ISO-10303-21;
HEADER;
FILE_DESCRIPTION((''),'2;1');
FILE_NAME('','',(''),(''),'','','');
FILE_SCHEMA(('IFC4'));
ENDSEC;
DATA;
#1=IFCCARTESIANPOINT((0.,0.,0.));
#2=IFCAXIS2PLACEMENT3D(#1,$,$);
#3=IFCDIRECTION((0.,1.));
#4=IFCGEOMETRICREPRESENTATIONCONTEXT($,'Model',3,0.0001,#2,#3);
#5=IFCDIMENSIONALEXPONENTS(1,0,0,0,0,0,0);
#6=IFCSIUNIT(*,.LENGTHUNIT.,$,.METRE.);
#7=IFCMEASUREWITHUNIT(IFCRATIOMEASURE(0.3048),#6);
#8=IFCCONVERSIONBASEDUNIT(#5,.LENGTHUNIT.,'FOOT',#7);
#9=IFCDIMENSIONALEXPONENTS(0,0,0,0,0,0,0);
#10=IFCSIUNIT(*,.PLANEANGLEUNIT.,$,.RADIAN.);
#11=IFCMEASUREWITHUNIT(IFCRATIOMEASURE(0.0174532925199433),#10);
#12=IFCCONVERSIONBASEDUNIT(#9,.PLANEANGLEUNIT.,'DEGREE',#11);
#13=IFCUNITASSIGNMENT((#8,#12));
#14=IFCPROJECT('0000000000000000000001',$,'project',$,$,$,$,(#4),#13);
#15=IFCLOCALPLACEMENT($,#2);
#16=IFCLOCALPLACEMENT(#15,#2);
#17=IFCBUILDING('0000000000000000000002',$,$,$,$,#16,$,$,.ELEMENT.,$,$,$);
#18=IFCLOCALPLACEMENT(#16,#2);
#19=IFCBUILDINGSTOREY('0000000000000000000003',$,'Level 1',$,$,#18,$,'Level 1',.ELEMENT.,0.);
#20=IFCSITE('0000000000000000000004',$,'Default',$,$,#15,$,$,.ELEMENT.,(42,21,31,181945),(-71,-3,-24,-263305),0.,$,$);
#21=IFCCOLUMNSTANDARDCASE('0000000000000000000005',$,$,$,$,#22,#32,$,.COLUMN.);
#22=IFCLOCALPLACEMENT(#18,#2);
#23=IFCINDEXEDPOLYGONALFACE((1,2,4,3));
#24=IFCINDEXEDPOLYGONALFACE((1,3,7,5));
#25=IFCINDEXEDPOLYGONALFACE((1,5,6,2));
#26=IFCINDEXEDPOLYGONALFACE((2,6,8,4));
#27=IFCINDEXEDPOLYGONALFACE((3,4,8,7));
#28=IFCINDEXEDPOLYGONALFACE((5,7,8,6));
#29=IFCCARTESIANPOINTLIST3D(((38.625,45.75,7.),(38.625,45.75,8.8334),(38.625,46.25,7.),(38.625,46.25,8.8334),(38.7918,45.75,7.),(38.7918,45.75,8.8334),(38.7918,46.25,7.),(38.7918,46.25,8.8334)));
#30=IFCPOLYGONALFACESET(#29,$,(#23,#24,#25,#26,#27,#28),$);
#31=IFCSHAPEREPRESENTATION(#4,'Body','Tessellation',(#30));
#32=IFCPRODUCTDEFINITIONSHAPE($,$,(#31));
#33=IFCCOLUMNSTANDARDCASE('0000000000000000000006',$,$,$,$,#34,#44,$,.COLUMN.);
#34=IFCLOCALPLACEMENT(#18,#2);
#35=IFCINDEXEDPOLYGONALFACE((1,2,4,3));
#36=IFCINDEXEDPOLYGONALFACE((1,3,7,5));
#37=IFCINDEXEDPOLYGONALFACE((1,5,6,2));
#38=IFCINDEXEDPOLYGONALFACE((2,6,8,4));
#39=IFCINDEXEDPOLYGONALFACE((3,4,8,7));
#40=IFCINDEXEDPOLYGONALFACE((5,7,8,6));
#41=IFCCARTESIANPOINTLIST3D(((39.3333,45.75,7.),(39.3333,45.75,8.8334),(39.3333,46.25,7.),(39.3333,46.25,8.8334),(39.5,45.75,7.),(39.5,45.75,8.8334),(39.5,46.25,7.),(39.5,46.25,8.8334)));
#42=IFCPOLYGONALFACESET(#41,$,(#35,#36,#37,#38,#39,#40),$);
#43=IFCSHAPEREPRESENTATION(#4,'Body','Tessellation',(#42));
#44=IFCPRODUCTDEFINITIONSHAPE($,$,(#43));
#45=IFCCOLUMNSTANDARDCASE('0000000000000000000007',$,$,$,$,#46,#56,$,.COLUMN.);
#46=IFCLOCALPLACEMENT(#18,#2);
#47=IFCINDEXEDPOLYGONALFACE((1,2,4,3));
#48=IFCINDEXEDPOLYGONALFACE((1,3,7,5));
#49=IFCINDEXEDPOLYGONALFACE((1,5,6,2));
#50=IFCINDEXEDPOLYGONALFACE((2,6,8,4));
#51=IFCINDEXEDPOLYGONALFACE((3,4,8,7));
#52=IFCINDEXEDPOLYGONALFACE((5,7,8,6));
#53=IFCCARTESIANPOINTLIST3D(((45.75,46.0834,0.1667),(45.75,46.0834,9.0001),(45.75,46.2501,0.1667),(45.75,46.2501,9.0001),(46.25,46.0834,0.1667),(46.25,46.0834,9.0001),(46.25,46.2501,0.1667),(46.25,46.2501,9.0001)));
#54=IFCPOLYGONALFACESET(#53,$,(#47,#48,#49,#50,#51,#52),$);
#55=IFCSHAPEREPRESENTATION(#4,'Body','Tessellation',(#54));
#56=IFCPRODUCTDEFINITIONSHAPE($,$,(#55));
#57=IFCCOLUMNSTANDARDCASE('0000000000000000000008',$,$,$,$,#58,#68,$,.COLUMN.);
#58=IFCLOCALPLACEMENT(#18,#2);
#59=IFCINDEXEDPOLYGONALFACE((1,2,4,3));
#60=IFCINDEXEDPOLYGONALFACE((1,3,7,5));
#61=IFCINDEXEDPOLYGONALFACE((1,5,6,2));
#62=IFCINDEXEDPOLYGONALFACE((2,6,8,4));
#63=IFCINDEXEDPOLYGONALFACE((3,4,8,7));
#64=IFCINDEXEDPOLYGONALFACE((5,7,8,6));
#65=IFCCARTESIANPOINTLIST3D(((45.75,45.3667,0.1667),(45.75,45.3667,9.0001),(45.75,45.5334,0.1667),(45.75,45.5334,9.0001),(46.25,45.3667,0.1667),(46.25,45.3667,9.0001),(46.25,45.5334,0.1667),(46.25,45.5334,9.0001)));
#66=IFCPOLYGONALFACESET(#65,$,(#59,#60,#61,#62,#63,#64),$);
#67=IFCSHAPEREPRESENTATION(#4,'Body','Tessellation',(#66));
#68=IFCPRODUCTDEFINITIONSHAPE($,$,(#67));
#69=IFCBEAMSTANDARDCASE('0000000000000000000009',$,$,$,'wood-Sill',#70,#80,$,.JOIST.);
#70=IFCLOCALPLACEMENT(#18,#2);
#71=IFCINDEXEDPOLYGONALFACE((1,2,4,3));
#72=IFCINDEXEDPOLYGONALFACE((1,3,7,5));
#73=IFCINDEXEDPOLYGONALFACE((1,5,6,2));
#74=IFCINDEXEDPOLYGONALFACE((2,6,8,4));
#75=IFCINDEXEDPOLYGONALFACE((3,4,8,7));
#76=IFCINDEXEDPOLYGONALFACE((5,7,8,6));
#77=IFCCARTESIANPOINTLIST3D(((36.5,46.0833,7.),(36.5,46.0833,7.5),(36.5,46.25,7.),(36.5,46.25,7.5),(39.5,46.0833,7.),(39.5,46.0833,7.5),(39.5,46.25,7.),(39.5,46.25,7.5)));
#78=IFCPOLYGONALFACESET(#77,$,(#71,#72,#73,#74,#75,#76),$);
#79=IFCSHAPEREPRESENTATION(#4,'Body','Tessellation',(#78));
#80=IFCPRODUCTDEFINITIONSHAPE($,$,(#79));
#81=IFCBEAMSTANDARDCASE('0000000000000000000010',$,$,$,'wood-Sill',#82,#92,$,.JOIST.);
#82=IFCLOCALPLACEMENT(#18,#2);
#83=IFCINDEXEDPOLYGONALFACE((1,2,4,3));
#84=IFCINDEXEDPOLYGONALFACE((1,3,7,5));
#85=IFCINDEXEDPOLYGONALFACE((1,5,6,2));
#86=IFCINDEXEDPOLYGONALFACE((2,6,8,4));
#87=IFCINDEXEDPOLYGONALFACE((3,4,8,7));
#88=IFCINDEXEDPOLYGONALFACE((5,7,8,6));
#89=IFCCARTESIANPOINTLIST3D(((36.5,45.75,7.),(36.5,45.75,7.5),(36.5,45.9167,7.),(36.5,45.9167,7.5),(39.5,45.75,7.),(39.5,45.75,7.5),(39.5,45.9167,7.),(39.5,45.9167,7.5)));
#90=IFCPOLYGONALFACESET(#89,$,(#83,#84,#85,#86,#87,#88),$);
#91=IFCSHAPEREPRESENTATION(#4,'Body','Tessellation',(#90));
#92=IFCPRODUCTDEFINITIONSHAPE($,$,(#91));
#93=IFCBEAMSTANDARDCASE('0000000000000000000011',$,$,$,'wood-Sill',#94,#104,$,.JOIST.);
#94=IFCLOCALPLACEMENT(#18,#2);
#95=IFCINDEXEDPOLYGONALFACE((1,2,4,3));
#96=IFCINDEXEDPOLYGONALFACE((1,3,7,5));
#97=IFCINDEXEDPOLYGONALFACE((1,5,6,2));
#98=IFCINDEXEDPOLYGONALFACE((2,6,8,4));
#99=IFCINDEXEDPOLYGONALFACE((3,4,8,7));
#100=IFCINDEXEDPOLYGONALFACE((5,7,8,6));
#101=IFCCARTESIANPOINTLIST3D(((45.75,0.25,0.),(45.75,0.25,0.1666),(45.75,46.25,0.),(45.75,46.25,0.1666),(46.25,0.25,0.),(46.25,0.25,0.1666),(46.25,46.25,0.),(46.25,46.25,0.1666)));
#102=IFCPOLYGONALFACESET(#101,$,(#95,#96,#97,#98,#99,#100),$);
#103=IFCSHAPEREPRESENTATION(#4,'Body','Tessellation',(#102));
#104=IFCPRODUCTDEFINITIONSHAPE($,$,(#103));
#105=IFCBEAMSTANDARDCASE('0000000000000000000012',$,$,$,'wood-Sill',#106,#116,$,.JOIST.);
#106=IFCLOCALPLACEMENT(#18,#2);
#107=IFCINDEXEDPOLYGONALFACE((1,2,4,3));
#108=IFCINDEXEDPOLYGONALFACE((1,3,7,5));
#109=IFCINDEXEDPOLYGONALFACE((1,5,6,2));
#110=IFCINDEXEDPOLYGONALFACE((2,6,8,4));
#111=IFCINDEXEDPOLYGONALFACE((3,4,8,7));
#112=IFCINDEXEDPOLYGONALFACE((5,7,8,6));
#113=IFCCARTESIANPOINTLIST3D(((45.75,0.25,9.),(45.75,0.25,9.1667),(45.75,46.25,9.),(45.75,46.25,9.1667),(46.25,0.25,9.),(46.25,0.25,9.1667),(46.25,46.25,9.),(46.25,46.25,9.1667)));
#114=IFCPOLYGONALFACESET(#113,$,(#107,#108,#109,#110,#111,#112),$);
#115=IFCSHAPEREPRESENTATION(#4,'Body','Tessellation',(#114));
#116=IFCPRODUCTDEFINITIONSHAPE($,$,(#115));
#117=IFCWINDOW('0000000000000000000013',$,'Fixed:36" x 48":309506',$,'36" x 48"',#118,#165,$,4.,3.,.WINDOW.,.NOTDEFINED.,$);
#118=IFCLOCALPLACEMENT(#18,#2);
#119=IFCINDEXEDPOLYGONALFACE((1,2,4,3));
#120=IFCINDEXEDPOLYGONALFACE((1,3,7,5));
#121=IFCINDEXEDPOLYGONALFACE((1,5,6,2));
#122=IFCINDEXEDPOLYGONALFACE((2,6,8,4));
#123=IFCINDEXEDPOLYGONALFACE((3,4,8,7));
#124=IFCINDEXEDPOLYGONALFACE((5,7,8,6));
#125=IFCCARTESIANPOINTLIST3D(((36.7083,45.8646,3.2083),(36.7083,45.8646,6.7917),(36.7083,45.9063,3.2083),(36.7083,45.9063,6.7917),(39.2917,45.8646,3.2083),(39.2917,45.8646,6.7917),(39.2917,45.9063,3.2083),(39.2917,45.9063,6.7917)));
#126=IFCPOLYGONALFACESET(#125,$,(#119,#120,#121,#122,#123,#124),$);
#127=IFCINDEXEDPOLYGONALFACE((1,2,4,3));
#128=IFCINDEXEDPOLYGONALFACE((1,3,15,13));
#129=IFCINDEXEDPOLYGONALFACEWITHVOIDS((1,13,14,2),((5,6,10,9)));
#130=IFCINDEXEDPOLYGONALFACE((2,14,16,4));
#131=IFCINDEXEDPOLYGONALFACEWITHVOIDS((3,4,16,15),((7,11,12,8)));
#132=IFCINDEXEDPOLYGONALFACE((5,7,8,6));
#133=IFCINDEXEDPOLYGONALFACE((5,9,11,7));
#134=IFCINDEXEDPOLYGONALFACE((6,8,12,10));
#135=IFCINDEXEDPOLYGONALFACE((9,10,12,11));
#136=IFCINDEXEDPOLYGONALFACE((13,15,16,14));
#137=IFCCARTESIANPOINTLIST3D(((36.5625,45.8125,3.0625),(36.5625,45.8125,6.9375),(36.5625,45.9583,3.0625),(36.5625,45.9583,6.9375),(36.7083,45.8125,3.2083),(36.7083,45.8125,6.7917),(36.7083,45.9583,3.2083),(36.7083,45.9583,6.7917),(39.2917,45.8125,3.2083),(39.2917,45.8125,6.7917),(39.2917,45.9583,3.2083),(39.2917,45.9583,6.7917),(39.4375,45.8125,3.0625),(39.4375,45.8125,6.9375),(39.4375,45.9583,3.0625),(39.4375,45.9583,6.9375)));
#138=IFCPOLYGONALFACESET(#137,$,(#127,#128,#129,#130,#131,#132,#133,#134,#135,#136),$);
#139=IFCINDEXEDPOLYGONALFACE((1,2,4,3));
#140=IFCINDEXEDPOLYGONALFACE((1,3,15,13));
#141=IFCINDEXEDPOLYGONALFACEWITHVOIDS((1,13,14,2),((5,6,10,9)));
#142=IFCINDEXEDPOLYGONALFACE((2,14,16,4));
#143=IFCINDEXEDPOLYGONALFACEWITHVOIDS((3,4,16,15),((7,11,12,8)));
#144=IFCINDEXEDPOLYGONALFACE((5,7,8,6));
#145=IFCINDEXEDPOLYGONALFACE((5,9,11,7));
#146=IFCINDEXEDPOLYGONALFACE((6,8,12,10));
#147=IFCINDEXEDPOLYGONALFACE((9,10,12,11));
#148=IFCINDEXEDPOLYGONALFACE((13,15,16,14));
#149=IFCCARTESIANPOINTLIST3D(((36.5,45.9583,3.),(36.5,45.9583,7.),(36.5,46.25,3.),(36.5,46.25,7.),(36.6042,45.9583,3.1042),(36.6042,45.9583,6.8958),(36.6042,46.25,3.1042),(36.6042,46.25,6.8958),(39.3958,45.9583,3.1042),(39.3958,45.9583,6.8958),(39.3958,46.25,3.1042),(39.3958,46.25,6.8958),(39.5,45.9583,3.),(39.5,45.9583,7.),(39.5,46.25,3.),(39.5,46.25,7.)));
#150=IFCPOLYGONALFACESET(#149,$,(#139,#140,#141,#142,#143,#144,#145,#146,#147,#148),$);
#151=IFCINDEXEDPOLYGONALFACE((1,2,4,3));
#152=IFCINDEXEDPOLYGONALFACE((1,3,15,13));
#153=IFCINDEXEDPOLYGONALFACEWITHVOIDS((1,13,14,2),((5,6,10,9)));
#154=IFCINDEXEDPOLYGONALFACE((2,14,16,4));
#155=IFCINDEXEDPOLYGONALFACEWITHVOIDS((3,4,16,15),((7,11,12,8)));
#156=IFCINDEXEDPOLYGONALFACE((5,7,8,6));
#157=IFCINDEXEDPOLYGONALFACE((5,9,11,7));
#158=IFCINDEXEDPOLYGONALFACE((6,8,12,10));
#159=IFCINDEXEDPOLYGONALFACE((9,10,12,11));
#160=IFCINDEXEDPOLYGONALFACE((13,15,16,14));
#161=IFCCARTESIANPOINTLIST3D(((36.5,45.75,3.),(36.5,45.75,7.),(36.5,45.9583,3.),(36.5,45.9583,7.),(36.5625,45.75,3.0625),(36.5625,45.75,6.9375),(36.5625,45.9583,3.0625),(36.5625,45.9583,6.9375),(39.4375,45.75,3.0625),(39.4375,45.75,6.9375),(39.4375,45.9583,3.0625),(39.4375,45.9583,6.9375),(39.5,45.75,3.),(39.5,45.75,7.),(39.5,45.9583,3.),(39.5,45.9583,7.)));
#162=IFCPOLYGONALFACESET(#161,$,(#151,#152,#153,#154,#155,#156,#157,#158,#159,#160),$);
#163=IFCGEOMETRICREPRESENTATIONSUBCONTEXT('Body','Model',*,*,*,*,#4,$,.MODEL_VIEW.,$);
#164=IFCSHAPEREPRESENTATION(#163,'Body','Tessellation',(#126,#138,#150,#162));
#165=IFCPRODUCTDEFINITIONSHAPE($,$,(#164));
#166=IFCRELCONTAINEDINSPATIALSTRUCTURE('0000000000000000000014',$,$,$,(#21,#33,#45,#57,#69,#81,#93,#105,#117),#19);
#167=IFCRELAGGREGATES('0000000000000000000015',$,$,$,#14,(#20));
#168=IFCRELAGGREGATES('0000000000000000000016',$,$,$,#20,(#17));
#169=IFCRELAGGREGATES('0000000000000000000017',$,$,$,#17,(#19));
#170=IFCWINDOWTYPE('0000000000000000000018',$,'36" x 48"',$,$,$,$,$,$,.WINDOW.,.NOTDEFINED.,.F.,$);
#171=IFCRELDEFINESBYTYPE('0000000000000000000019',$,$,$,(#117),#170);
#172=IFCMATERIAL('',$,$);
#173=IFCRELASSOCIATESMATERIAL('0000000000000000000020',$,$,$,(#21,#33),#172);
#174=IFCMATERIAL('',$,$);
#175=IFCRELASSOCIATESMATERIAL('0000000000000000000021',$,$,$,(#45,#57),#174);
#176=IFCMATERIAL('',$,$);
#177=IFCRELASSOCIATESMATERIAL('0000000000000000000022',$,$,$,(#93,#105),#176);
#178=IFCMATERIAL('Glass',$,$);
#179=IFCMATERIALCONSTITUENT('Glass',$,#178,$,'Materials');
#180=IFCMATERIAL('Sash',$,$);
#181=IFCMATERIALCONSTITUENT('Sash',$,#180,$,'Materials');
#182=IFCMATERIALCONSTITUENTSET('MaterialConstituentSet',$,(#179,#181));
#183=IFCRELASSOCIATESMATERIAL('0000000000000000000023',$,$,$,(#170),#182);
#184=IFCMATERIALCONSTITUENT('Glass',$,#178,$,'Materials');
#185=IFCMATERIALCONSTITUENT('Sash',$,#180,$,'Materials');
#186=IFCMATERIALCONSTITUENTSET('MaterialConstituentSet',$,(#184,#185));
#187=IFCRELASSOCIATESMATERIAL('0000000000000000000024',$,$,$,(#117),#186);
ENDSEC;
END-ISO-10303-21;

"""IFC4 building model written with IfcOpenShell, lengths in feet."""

from ifc_helpers import new_model, entity, si_unit, converted_unit, direction, frame, frame_2d, origin, origin_with_axes, place, context, subcontext, project, spatial, polyline, rectangle, outline, extrude, source, transform, mapped, material, constituent, constituent_set, type_object, type_shapes, element, save


model = new_model("IFC4")

# Units and contexts
model_context = context("Model", 3, precision=0.0001, world=origin(), true_north=direction((0.0, 1.0)))
body_context = subcontext(model_context, "Body", "Model", "MODEL_VIEW")
ifc_project = project(units=[converted_unit("LENGTHUNIT", "FOOT", entity("IfcRatioMeasure", 0.3048), si_unit("LENGTHUNIT", "METRE"), dimensions=[1, 0, 0, 0, 0, 0, 0]), converted_unit("PLANEANGLEUNIT", "DEGREE", entity("IfcRatioMeasure", 0.0174532925199433), si_unit("PLANEANGLEUNIT", "RADIAN"), dimensions=[0, 0, 0, 0, 0, 0, 0])], contexts=[model_context])

# Site, building, storey
site_placement = place(None, origin())
site = spatial("IfcSite", under=ifc_project, at=site_placement, Name="Default", CompositionType="ELEMENT", RefLatitude=(42, 21, 31, 181945), RefLongitude=(-71, -3, -24, -263305), RefElevation=0.0)
building_placement = place(site_placement, origin())
building = spatial("IfcBuilding", under=site, at=building_placement, CompositionType="ELEMENT")
storey_placement = place(building_placement, origin())
storey = spatial("IfcBuildingStorey", under=building, at=storey_placement, Name="Level 1", LongName="Level 1", CompositionType="ELEMENT", Elevation=0.0)

# Columns
placement_1 = place(storey_placement, frame((-0.25, 46.0, 0.0)))
ifc_material_1 = material(Name="")
for number, where, z_axis, x_axis in (
    (1, (38.9584, 0.0, 7.0), (0.0, 0.0, 1.0), (1.0, 0.0, 0.0)),
    (2, (39.6667, 0.0, 7.0), (0.0, 0.0, 1.0), (1.0, 0.0, 0.0)),
):
    element("IfcColumnStandardCase", number, at=place(placement_1, frame(where, z_axis=z_axis, x_axis=x_axis)), inside=storey, material=ifc_material_1, PredefinedType="COLUMN", context=model_context, shape_type="SweptSolid", body=[
        extrude(rectangle(XDim=0.1667, YDim=0.5), origin(), (0.0, 0.0, 1.0), 1.8334),
    ])
ifc_material_2 = material(Name="")
placement_2 = place(storey_placement, frame((46.0, 46.25, 0.0), z_axis=(0.0, 0.0, 1.0), x_axis=(0.0, -1.0, 0.0)))
for number, where, z_axis, x_axis in (
    (3, (0.0833, 0.0, 0.1667), (0.0, 0.0, 1.0), (1.0, 0.0, 0.0)),
    (4, (0.8, 0.0, 0.1667), (0.0, 0.0, 1.0), (1.0, 0.0, 0.0)),
):
    element("IfcColumnStandardCase", number, at=place(placement_2, frame(where, z_axis=z_axis, x_axis=x_axis)), inside=storey, material=ifc_material_2, PredefinedType="COLUMN", context=model_context, shape_type="SweptSolid", body=[
        extrude(rectangle(XDim=0.1667, YDim=0.5), origin(), (0.0, 0.0, 1.0), 8.8334),
    ])

# Beams
for number, where, z_axis, x_axis in (
    (5, (36.75, 0.1667, 7.25), (1.0, 0.0, 0.0), (0.0, 0.0, 1.0)),
    (6, (36.75, -0.1667, 7.25), (1.0, 0.0, 0.0), (0.0, 0.0, 1.0)),
):
    element("IfcBeamStandardCase", number, at=place(placement_1, frame(where, z_axis=z_axis, x_axis=x_axis)), inside=storey, ObjectType="wood-Sill", PredefinedType="JOIST", context=model_context, shape_type="SweptSolid", body=[
        extrude(rectangle(XDim=0.5, YDim=0.1667), origin_with_axes(), (0.0, 0.0, 1.0), 3.0),
    ])
ifc_material_3 = material(Name="")
for number, where, z_axis, x_axis in (
    (7, (0.0, 0.0, 0.0833), (1.0, 0.0, 0.0), (0.0, 0.0, 1.0)),
    (8, (0.0, 0.0, 9.0834), (1.0, 0.0, 0.0), (0.0, 0.0, 1.0)),
):
    element("IfcBeamStandardCase", number, at=place(placement_2, frame(where, z_axis=z_axis, x_axis=x_axis)), inside=storey, material=ifc_material_3, ObjectType="wood-Sill", PredefinedType="JOIST", context=model_context, shape_type="SweptSolid", body=[
        extrude(rectangle(XDim=0.1667, YDim=0.5), origin_with_axes(), (0.0, 0.0, 1.0), 46.0),
    ])

# Window
ifc_material_4 = material(Name="Glass")
ifc_constituent_1 = constituent(ifc_material_4, Name="Glass", Category="Materials")
ifc_material_5 = material(Name="Sash")
ifc_constituent_2 = constituent(ifc_material_5, Name="Sash", Category="Materials")
ifc_constituent_set_1 = constituent_set(constituents=[ifc_constituent_1, ifc_constituent_2], Name="MaterialConstituentSet")
ifc_constituent_3 = constituent(ifc_material_4, Name="Glass", Category="Materials")
ifc_constituent_4 = constituent(ifc_material_5, Name="Sash", Category="Materials")
ifc_constituent_set_2 = constituent_set(constituents=[ifc_constituent_3, ifc_constituent_4], Name="MaterialConstituentSet")
window_type = type_object("IfcWindowType", Name="36\" x 48\"", ParameterTakesPrecedence=False, PartitioningType="NOTDEFINED", PredefinedType="WINDOW", material=ifc_constituent_set_2)
shared_shape = source(origin(), body_context, "Body", "SweptSolid", [
    extrude(rectangle(XDim=0.0417, YDim=2.5833, at=frame_2d((0.0, 0.0), x_axis=(1.0, 0.0))), frame((1.5, 0.3646, 0.2083), z_axis=(0.0, 0.0, 1.0), x_axis=(0.0, 1.0, 0.0)), (0.0, 0.0, 1.0), 3.5833),
    extrude(outline(polyline([(-1.4375, -1.9375), (1.4375, -1.9375), (1.4375, 1.9375), (-1.4375, 1.9375), (-1.4375, -1.9375)]), holes=[polyline([(-1.2917, -1.7917), (-1.2917, 1.7917), (1.2917, 1.7917), (1.2917, -1.7917), (-1.2917, -1.7917)])]), frame((1.5, 0.2917, 2.0), z_axis=(0.0, 1.0, 0.0), x_axis=(1.0, 0.0, 0.0)), (0.0, 0.0, 1.0), 0.1458),
    extrude(outline(polyline([(-1.5, -2.0), (1.5, -2.0), (1.5, 2.0), (-1.5, 2.0), (-1.5, -2.0)]), holes=[polyline([(-1.3958, -1.8958), (-1.3958, 1.8958), (1.3958, 1.8958), (1.3958, -1.8958), (-1.3958, -1.8958)])]), frame((1.5, 0.0, 2.0), z_axis=(0.0, 1.0, 0.0), x_axis=(1.0, 0.0, 0.0)), (0.0, 0.0, 1.0), 0.2917),
    extrude(outline(polyline([(-2.0, -1.5), (2.0, -1.5), (2.0, 1.5), (-2.0, 1.5), (-2.0, -1.5)]), holes=[polyline([(-1.9375, -1.4375), (-1.9375, 1.4375), (1.9375, 1.4375), (1.9375, -1.4375), (-1.9375, -1.4375)])]), frame((1.5, 0.2917, 2.0), z_axis=(0.0, 1.0, 0.0), x_axis=(0.0, 0.0, -1.0)), (0.0, 0.0, 1.0), 0.2083),
])
type_shapes(window_type, [shared_shape])
placement_3 = place(placement_1, frame((39.75, 0.25, 3.0)))
window_placement = place(placement_3, frame((0.0, 0.0, 0.0), z_axis=(0.0, 0.0, 1.0), x_axis=(-1.0, 0.0, 0.0)))
element("IfcWindow", 9, at=window_placement, inside=storey, type_object=window_type, material=ifc_constituent_set_1, Name="Fixed:36\" x 48\":309506", ObjectType="36\" x 48\"", OverallHeight=4.0, OverallWidth=3.0, PartitioningType="NOTDEFINED", PredefinedType="WINDOW", context=body_context, shape_type="MappedRepresentation", body=[
    mapped(shared_shape, transform((0.0, 0.0, 0.0), scale=1.0)),
])

save(model, "model.ifc")
